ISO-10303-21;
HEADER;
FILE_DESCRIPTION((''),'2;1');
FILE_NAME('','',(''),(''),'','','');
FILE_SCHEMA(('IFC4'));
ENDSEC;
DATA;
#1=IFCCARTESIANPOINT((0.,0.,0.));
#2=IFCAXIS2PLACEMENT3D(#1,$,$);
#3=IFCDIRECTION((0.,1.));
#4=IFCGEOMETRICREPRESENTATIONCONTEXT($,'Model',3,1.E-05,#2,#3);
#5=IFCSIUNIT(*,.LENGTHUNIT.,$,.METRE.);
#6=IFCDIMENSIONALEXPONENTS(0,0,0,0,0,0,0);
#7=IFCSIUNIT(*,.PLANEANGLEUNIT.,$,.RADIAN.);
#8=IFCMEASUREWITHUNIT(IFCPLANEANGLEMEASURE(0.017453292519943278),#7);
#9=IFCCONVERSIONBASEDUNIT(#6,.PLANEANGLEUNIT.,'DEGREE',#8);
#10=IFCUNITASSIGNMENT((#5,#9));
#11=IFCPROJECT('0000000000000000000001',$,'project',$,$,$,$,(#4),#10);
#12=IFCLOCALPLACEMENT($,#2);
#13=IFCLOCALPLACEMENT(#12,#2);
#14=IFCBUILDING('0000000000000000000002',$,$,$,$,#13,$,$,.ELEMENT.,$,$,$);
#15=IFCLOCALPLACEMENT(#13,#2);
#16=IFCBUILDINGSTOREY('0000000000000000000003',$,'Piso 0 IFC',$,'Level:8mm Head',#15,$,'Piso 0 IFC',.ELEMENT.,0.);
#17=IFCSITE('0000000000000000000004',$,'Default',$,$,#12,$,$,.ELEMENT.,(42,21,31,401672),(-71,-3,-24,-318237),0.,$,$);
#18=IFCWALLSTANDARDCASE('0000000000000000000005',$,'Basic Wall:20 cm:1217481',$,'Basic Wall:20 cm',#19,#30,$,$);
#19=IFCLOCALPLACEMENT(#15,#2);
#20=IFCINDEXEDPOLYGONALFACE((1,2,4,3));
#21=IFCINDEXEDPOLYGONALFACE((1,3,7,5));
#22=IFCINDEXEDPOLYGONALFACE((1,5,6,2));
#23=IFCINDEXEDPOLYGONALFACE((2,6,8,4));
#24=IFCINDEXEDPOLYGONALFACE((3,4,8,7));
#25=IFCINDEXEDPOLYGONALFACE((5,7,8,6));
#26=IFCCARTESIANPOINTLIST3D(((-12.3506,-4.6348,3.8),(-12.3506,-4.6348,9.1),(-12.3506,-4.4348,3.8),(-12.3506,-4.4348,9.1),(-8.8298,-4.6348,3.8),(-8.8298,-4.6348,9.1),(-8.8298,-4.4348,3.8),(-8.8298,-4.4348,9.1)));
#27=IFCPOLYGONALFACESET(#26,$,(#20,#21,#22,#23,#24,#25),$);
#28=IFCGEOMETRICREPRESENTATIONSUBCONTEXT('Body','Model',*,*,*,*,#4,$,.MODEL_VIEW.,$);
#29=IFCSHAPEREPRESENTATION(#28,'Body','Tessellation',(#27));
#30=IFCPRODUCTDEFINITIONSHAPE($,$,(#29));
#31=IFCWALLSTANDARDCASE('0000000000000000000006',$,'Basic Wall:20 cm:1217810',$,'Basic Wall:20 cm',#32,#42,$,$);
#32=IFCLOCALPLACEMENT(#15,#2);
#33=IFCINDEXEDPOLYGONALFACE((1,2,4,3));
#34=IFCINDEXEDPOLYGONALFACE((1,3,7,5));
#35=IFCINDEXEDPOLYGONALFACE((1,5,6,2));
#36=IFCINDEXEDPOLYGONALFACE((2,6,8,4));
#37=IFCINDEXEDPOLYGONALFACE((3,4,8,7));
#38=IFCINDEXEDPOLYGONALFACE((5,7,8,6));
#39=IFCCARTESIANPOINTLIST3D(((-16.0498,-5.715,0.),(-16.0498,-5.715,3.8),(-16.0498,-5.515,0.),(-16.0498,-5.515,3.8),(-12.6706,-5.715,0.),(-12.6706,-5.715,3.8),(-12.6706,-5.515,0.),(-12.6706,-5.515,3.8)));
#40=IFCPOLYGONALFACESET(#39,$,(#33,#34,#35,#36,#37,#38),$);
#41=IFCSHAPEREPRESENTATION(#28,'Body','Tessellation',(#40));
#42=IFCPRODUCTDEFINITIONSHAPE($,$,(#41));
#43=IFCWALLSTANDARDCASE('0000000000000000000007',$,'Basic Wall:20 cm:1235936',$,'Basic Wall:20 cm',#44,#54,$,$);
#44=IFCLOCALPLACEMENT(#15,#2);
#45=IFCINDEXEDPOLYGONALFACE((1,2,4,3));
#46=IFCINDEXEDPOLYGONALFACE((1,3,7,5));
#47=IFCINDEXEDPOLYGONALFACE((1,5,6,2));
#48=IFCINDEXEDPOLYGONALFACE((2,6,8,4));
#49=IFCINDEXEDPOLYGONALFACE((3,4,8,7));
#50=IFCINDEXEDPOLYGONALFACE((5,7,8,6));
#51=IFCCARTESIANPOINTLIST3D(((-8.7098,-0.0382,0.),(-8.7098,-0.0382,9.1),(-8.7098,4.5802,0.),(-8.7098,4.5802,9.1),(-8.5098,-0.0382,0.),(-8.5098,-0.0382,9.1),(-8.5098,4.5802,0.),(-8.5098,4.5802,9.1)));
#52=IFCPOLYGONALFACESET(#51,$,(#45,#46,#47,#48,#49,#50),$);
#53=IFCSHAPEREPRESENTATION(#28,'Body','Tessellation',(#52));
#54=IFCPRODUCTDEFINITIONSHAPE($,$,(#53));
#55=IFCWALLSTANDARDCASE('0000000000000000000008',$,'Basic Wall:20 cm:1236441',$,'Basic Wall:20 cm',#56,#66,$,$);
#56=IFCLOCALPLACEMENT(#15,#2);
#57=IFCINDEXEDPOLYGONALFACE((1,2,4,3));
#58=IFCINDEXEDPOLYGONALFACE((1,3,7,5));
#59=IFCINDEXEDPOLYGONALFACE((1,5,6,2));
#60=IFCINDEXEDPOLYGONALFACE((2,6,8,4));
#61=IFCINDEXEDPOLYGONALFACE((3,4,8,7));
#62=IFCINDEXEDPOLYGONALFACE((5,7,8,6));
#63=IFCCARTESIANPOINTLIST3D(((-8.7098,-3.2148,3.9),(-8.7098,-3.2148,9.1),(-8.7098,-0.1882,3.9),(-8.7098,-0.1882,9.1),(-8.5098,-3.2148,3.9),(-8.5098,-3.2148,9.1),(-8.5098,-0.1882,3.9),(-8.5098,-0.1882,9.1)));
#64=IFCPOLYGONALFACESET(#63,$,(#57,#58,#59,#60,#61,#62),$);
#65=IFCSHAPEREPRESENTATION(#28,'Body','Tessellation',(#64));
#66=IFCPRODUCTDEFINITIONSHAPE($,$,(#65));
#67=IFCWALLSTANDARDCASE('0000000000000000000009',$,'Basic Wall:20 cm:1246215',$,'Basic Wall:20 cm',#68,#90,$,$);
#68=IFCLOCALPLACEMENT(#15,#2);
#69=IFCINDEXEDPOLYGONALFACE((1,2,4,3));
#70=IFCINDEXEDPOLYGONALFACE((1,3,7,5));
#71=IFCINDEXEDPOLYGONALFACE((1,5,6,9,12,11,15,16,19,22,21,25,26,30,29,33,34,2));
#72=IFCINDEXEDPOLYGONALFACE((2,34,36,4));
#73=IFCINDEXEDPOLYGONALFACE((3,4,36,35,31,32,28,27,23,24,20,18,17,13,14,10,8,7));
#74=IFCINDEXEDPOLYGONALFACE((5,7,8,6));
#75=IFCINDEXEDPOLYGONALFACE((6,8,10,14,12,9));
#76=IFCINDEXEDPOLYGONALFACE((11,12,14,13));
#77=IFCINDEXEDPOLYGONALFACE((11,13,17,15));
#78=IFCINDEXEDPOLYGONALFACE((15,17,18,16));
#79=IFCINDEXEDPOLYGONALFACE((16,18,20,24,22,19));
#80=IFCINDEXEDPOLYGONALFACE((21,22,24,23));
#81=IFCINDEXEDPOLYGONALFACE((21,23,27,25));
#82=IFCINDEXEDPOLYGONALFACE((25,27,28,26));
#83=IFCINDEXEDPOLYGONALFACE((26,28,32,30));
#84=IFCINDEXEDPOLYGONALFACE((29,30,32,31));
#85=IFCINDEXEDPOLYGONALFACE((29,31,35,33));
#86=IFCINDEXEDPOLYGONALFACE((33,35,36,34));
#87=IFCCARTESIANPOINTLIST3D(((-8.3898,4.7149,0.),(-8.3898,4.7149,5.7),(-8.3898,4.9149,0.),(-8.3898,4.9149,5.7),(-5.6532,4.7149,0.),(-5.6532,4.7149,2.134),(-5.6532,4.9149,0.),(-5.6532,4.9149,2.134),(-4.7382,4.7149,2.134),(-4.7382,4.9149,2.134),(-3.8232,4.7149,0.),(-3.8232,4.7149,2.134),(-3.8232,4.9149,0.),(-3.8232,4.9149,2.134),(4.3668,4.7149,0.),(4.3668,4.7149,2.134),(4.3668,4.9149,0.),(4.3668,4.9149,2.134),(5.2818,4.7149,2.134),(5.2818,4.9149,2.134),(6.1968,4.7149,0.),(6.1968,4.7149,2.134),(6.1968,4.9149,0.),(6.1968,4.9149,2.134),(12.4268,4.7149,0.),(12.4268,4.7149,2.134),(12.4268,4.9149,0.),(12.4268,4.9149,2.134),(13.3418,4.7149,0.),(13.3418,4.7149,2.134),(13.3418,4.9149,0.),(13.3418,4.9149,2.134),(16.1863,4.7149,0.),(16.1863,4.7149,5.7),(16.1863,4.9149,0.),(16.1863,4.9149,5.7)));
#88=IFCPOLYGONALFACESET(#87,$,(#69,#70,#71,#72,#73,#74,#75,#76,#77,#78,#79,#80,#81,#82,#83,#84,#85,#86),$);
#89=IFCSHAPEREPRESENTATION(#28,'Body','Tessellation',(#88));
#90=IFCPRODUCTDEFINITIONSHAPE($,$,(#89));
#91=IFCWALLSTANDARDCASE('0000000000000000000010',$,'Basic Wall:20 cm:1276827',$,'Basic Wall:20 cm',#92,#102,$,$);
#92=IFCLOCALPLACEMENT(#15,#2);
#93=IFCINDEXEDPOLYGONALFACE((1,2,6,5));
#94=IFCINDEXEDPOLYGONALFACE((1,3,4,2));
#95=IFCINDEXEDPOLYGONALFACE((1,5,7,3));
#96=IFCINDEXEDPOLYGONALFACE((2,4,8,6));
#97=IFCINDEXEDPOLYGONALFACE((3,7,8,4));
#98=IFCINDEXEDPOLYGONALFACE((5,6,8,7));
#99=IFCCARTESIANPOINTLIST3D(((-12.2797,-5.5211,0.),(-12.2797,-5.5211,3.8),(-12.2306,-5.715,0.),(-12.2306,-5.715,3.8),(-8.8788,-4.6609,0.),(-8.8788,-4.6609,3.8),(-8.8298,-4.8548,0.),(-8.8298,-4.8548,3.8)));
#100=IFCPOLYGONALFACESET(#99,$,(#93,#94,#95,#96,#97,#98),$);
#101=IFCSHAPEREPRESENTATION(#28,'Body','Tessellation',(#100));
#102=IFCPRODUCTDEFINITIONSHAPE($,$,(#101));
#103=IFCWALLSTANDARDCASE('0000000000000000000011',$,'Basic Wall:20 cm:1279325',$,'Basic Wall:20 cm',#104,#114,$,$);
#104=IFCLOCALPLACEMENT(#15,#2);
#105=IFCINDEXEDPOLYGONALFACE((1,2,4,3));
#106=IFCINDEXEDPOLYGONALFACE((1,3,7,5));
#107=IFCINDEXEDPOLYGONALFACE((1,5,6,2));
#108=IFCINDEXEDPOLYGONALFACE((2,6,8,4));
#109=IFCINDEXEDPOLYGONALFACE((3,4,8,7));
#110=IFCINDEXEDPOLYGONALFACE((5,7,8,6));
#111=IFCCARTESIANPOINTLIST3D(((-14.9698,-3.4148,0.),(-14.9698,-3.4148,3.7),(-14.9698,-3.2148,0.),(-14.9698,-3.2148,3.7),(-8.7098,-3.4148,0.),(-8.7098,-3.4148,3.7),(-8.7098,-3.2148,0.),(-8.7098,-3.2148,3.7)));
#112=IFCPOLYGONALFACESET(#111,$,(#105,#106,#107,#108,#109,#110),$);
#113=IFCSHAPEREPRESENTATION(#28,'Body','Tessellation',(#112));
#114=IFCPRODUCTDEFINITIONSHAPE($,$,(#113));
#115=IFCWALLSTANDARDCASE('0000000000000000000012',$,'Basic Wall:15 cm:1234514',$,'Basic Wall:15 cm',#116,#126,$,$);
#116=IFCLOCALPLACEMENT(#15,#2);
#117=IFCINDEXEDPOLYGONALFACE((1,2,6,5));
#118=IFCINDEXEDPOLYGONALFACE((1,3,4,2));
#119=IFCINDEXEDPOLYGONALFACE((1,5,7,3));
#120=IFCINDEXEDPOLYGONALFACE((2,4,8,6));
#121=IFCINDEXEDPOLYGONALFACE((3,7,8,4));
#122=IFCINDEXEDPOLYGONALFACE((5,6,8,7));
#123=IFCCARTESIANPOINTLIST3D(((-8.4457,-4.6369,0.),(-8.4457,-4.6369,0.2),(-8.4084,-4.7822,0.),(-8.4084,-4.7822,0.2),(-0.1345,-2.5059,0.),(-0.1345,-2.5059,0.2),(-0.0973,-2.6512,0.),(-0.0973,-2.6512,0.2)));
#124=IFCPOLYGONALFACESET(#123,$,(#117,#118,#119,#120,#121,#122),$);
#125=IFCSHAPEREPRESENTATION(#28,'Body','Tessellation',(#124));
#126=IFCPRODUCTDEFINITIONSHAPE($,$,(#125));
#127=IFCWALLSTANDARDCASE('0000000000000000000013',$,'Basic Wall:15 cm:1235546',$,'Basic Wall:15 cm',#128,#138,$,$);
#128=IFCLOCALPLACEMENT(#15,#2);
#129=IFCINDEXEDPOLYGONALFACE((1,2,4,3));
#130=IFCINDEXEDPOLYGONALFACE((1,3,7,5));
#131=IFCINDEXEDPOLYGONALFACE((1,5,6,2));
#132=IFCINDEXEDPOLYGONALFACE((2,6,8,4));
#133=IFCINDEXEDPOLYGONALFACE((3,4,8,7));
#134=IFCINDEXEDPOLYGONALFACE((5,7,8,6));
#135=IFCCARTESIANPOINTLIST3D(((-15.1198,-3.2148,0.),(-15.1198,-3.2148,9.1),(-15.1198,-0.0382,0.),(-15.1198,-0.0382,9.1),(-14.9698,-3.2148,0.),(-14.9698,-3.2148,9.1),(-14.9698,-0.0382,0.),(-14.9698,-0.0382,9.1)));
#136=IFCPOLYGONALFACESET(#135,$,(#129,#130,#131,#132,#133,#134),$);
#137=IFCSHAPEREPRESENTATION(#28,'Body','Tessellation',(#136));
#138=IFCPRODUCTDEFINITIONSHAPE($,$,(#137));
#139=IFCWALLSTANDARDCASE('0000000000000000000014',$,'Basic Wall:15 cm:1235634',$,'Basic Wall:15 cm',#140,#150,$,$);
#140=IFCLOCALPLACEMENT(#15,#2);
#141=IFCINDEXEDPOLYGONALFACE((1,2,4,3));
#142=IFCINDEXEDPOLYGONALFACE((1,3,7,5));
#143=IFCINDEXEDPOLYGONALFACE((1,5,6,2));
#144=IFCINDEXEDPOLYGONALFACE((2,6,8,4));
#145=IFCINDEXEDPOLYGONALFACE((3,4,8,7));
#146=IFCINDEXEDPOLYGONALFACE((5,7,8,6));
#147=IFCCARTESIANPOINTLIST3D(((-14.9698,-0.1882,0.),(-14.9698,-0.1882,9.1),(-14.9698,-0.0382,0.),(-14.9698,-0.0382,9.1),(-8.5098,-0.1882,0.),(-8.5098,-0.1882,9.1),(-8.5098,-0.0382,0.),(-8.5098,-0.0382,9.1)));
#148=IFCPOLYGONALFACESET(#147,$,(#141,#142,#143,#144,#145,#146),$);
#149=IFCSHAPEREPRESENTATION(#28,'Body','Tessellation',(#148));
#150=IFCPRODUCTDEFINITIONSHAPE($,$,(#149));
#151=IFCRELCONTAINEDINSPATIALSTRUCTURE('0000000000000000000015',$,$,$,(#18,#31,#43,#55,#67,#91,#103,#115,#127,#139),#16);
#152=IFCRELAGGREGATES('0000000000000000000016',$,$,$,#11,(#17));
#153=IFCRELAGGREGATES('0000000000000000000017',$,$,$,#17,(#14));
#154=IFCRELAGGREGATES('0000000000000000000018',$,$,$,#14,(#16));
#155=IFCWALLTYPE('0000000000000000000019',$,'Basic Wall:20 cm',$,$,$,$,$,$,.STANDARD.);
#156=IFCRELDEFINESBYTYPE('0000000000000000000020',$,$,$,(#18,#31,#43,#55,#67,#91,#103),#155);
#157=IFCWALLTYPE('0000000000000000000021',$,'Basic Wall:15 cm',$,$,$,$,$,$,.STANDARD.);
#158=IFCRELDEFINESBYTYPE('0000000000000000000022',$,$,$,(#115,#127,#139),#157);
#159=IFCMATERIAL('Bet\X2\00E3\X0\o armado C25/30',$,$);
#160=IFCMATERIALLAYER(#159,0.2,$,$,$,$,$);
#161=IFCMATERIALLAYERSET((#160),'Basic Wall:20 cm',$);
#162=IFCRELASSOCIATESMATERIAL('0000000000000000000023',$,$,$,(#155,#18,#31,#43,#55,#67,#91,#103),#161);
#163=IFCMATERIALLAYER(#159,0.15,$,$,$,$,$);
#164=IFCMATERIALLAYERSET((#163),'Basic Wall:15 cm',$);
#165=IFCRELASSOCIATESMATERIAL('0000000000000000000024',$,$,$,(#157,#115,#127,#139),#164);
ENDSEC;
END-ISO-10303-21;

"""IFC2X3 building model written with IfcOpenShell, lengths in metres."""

from ifc_helpers import new_model, entity, si_unit, converted_unit, direction, frame, frame_2d, origin, place, context, subcontext, project, spatial, polyline, rectangle, extrude, clip, bounded_halfspace, material, layer, layer_set, layer_usage, type_object, element, save


model = new_model("IFC2X3")

# Units and contexts
model_context = context("Model", 3, precision=1e-05, world=origin(), true_north=direction((0.0, 1.0)))
body_context = subcontext(model_context, "Body", "Model", "MODEL_VIEW")
ifc_project = project(units=[si_unit("LENGTHUNIT", "METRE"), converted_unit("PLANEANGLEUNIT", "DEGREE", entity("IfcPlaneAngleMeasure", 0.017453292519943278), si_unit("PLANEANGLEUNIT", "RADIAN"), dimensions=[0, 0, 0, 0, 0, 0, 0])], contexts=[model_context])

# Site, building, storey
site_placement = place(None, origin())
site = spatial("IfcSite", under=ifc_project, at=site_placement, Name="Default", CompositionType="ELEMENT", RefLatitude=(42, 21, 31, 401672), RefLongitude=(-71, -3, -24, -318237), RefElevation=0.0)
building_placement = place(site_placement, origin())
building = spatial("IfcBuilding", under=site, at=building_placement, CompositionType="ELEMENT")
storey_placement = place(building_placement, origin())
storey = spatial("IfcBuildingStorey", under=building, at=storey_placement, Name="Piso 0 IFC", ObjectType="Level:8mm Head", LongName="Piso 0 IFC", CompositionType="ELEMENT", Elevation=0.0)

# Shared definitions
ifc_material_1 = material(Name="Betão armado C25/30")
ifc_layer_1 = layer(ifc_material_1, 0.2)
ifc_layer_set_1 = layer_set([ifc_layer_1], Name="Basic Wall:20 cm")
wall_type_1 = type_object("IfcWallType", Name="Basic Wall:20 cm", PredefinedType="STANDARD", material=ifc_layer_set_1)

# Walls
ifc_layer_usage_1 = layer_usage(ifc_layer_set_1, "AXIS2", "NEGATIVE", 0.1)
wall_1_placement = place(storey_placement, frame((-12.3506, -4.5348, 3.8)))
element("IfcWallStandardCase", 1, at=wall_1_placement, inside=storey, type_object=wall_type_1, material=ifc_layer_usage_1, Name="Basic Wall:20 cm:1217481", ObjectType="Basic Wall:20 cm", context=body_context, shape_type="Clipping", body=[
    clip(extrude(rectangle(XDim=3.5208, YDim=0.2, at=frame_2d((1.7604, 0.0), x_axis=(-1.0, 0.0))), origin(), (0.0, 0.0, 1.0), 5.3), bounded_halfspace(frame((0.0, -0.1, 5.3), z_axis=(0.0, 0.0, -1.0), x_axis=(-1.0, 0.0, 0.0)), True, frame((0.0, -0.1, 5.3)), polyline([(0.0, 0.0), (3.5208, 0.0), (3.5208, 0.2), (0.0, 0.2), (0.0, 0.0)]))),
])
ifc_layer_usage_2 = layer_usage(ifc_layer_set_1, "AXIS2", "NEGATIVE", 0.1)
wall_2_placement = place(storey_placement, frame((-16.0498, -5.615, 0.0)))
element("IfcWallStandardCase", 2, at=wall_2_placement, inside=storey, type_object=wall_type_1, material=ifc_layer_usage_2, Name="Basic Wall:20 cm:1217810", ObjectType="Basic Wall:20 cm", context=body_context, shape_type="SweptSolid", body=[
    extrude(rectangle(XDim=3.3792, YDim=0.2, at=frame_2d((1.6896, 0.0), x_axis=(-1.0, 0.0))), origin(), (0.0, 0.0, 1.0), 3.8),
])
ifc_layer_usage_3 = layer_usage(ifc_layer_set_1, "AXIS2", "NEGATIVE", 0.1)
wall_3_placement = place(storey_placement, frame((-8.6098, -0.0382, 0.0), z_axis=(0.0, 0.0, 1.0), x_axis=(0.0, 1.0, 0.0)))
element("IfcWallStandardCase", 3, at=wall_3_placement, inside=storey, type_object=wall_type_1, material=ifc_layer_usage_3, Name="Basic Wall:20 cm:1235936", ObjectType="Basic Wall:20 cm", context=body_context, shape_type="Clipping", body=[
    clip(extrude(rectangle(XDim=4.6184, YDim=0.2, at=frame_2d((2.3092, 0.0), x_axis=(-1.0, 0.0))), origin(), (0.0, 0.0, 1.0), 9.1), bounded_halfspace(frame((0.0, -0.1, 9.1), z_axis=(0.0, 0.0, -1.0), x_axis=(0.0, 1.0, 0.0)), True, frame((0.0, -0.1, 9.1)), polyline([(0.0, 0.0), (4.6184, 0.0), (4.6184, 0.2), (0.0, 0.2), (0.0, 0.0)]))),
])
ifc_layer_usage_4 = layer_usage(ifc_layer_set_1, "AXIS2", "NEGATIVE", 0.1)
wall_4_placement = place(storey_placement, frame((-8.6098, -0.1882, 3.9), z_axis=(0.0, 0.0, 1.0), x_axis=(0.0, -1.0, 0.0)))
element("IfcWallStandardCase", 4, at=wall_4_placement, inside=storey, type_object=wall_type_1, material=ifc_layer_usage_4, Name="Basic Wall:20 cm:1236441", ObjectType="Basic Wall:20 cm", context=body_context, shape_type="Clipping", body=[
    clip(extrude(rectangle(XDim=3.0266, YDim=0.2, at=frame_2d((1.5133, 0.0), x_axis=(-1.0, 0.0))), origin(), (0.0, 0.0, 1.0), 5.2), bounded_halfspace(frame((0.0, -0.1, 5.2), z_axis=(0.0, 0.0, -1.0), x_axis=(0.0, -1.0, 0.0)), True, frame((0.0, -0.1, 5.2)), polyline([(0.0, 0.0), (3.0266, 0.0), (3.0266, 0.2), (0.0, 0.2), (0.0, 0.0)]))),
])

# Wall, openings
ifc_layer_usage_5 = layer_usage(ifc_layer_set_1, "AXIS2", "NEGATIVE", 0.1)
wall_5_placement = place(storey_placement, frame((-8.3898, 4.8149, 0.0)))
wall_5 = element("IfcWallStandardCase", 5, at=wall_5_placement, inside=storey, type_object=wall_type_1, material=ifc_layer_usage_5, Name="Basic Wall:20 cm:1246215", ObjectType="Basic Wall:20 cm", context=body_context, shape_type="SweptSolid", body=[
    extrude(rectangle(XDim=24.5761, YDim=0.2, at=frame_2d((12.2881, 0.0), x_axis=(-1.0, 0.0))), origin(), (0.0, 0.0, 1.0), 5.7),
])
opening_1_placement = place(wall_5_placement, frame((8.3898, -4.8149, 0.0)))
element("IfcOpeningElement", 6, at=opening_1_placement, cuts=wall_5, ObjectType="Opening", context=body_context, shape_type="SweptSolid", body=[
    extrude(rectangle(XDim=2.134, YDim=0.915, at=frame_2d((0.0, 0.0), x_axis=(0.0, 1.0))), frame((12.8843, 3.1909, 1.067), z_axis=(0.0, 1.0, 0.0), x_axis=(1.0, 0.0, 0.0)), (0.0, 0.0, 1.0), 3.048),
])
opening_2_placement = place(wall_5_placement, frame((8.3898, -4.8149, 0.0)))
element("IfcOpeningElement", 7, at=opening_2_placement, cuts=wall_5, ObjectType="Opening", context=body_context, shape_type="SweptSolid", body=[
    extrude(rectangle(XDim=2.134, YDim=0.915, at=frame_2d((0.0, 0.0), x_axis=(0.0, 1.0))), frame((-5.1957, 3.1909, 1.067), z_axis=(0.0, 1.0, 0.0), x_axis=(1.0, 0.0, 0.0)), (0.0, 0.0, 1.0), 3.048),
])
opening_3_placement = place(wall_5_placement, frame((8.3898, -4.8149, 0.0)))
element("IfcOpeningElement", 8, at=opening_3_placement, cuts=wall_5, ObjectType="Opening", context=body_context, shape_type="SweptSolid", body=[
    extrude(rectangle(XDim=2.134, YDim=0.915, at=frame_2d((0.0, 0.0), x_axis=(0.0, 1.0))), frame((-4.2807, 3.1909, 1.067), z_axis=(0.0, 1.0, 0.0), x_axis=(1.0, 0.0, 0.0)), (0.0, 0.0, 1.0), 3.048),
])
opening_4_placement = place(wall_5_placement, frame((8.3898, -4.8149, 0.0)))
element("IfcOpeningElement", 9, at=opening_4_placement, cuts=wall_5, ObjectType="Opening", context=body_context, shape_type="SweptSolid", body=[
    extrude(rectangle(XDim=2.134, YDim=0.915, at=frame_2d((0.0, 0.0), x_axis=(0.0, 1.0))), frame((5.7393, 3.1909, 1.067), z_axis=(0.0, 1.0, 0.0), x_axis=(1.0, 0.0, 0.0)), (0.0, 0.0, 1.0), 3.048),
])
opening_5_placement = place(wall_5_placement, frame((8.3898, -4.8149, 0.0)))
element("IfcOpeningElement", 10, at=opening_5_placement, cuts=wall_5, ObjectType="Opening", context=body_context, shape_type="SweptSolid", body=[
    extrude(rectangle(XDim=2.134, YDim=0.915, at=frame_2d((0.0, 0.0), x_axis=(0.0, 1.0))), frame((4.8243, 3.1909, 1.067), z_axis=(0.0, 1.0, 0.0), x_axis=(1.0, 0.0, 0.0)), (0.0, 0.0, 1.0), 3.048),
])

# Walls
ifc_layer_usage_6 = layer_usage(ifc_layer_set_1, "AXIS2", "NEGATIVE", 0.1)
wall_6_placement = place(storey_placement, frame((-12.2552, -5.6181, 0.0), z_axis=(0.0, 0.0, 1.0), x_axis=(0.969469, 0.245216, 0.0)))
element("IfcWallStandardCase", 11, at=wall_6_placement, inside=storey, type_object=wall_type_1, material=ifc_layer_usage_6, Name="Basic Wall:20 cm:1276827", ObjectType="Basic Wall:20 cm", context=body_context, shape_type="SweptSolid", body=[
    extrude(rectangle(XDim=3.5079, YDim=0.2, at=frame_2d((1.754, 0.0), x_axis=(-1.0, 0.0))), origin(), (0.0, 0.0, 1.0), 3.8),
])
ifc_layer_usage_7 = layer_usage(ifc_layer_set_1, "AXIS2", "NEGATIVE", 0.1)
wall_7_placement = place(storey_placement, frame((-14.9698, -3.3148, 0.0)))
element("IfcWallStandardCase", 12, at=wall_7_placement, inside=storey, type_object=wall_type_1, material=ifc_layer_usage_7, Name="Basic Wall:20 cm:1279325", ObjectType="Basic Wall:20 cm", context=body_context, shape_type="SweptSolid", body=[
    extrude(rectangle(XDim=6.26, YDim=0.2, at=frame_2d((3.13, 0.0), x_axis=(-1.0, 0.0))), origin(), (0.0, 0.0, 1.0), 3.7),
])
ifc_layer_2 = layer(ifc_material_1, 0.15)
ifc_layer_set_2 = layer_set([ifc_layer_2], Name="Basic Wall:15 cm")
ifc_layer_usage_8 = layer_usage(ifc_layer_set_2, "AXIS2", "NEGATIVE", 0.075)
wall_type_2 = type_object("IfcWallType", Name="Basic Wall:15 cm", PredefinedType="STANDARD", material=ifc_layer_set_2)
wall_8_placement = place(storey_placement, frame((-8.4271, -4.7095, 0.0), z_axis=(0.0, 0.0, 1.0), x_axis=(0.968666, 0.248367, 0.0)))
element("IfcWallStandardCase", 13, at=wall_8_placement, inside=storey, type_object=wall_type_2, material=ifc_layer_usage_8, Name="Basic Wall:15 cm:1234514", ObjectType="Basic Wall:15 cm", context=body_context, shape_type="SweptSolid", body=[
    extrude(rectangle(XDim=8.58, YDim=0.15, at=frame_2d((4.29, 0.0), x_axis=(-1.0, 0.0))), origin(), (0.0, 0.0, 1.0), 0.2),
])
ifc_layer_usage_9 = layer_usage(ifc_layer_set_2, "AXIS2", "NEGATIVE", 0.075)
wall_9_placement = place(storey_placement, frame((-15.0448, -3.2148, 0.0), z_axis=(0.0, 0.0, 1.0), x_axis=(0.0, 1.0, 0.0)))
element("IfcWallStandardCase", 14, at=wall_9_placement, inside=storey, type_object=wall_type_2, material=ifc_layer_usage_9, Name="Basic Wall:15 cm:1235546", ObjectType="Basic Wall:15 cm", context=body_context, shape_type="Clipping", body=[
    clip(extrude(rectangle(XDim=3.1766, YDim=0.15, at=frame_2d((1.5883, 0.0), x_axis=(-1.0, 0.0))), origin(), (0.0, 0.0, 1.0), 9.1), bounded_halfspace(frame((0.0, -0.075, 9.1), z_axis=(0.0, 0.0, -1.0), x_axis=(0.0, 1.0, 0.0)), True, frame((0.0, -0.075, 9.1)), polyline([(0.0, 0.0), (3.0266, 0.0), (3.1766, 0.0), (3.1766, 0.15), (0.0, 0.15), (0.0, 0.0)]))),
])
ifc_layer_usage_10 = layer_usage(ifc_layer_set_2, "AXIS2", "NEGATIVE", 0.075)
wall_10_placement = place(storey_placement, frame((-14.9698, -0.1132, 0.0)))
element("IfcWallStandardCase", 15, at=wall_10_placement, inside=storey, type_object=wall_type_2, material=ifc_layer_usage_10, Name="Basic Wall:15 cm:1235634", ObjectType="Basic Wall:15 cm", context=body_context, shape_type="Clipping", body=[
    clip(extrude(rectangle(XDim=6.46, YDim=0.15, at=frame_2d((3.23, 0.0), x_axis=(-1.0, 0.0))), origin(), (0.0, 0.0, 1.0), 9.1), bounded_halfspace(frame((0.0, -0.075, 9.1), z_axis=(0.0, 0.0, -1.0), x_axis=(-1.0, 0.0, 0.0)), True, frame((0.0, -0.075, 9.1)), polyline([(0.0, 0.0), (6.26, 0.0), (6.46, 0.0), (6.46, 0.15), (6.26, 0.15), (0.0, 0.15), (0.0, 0.0)]))),
])

save(model, "model.ifc")
